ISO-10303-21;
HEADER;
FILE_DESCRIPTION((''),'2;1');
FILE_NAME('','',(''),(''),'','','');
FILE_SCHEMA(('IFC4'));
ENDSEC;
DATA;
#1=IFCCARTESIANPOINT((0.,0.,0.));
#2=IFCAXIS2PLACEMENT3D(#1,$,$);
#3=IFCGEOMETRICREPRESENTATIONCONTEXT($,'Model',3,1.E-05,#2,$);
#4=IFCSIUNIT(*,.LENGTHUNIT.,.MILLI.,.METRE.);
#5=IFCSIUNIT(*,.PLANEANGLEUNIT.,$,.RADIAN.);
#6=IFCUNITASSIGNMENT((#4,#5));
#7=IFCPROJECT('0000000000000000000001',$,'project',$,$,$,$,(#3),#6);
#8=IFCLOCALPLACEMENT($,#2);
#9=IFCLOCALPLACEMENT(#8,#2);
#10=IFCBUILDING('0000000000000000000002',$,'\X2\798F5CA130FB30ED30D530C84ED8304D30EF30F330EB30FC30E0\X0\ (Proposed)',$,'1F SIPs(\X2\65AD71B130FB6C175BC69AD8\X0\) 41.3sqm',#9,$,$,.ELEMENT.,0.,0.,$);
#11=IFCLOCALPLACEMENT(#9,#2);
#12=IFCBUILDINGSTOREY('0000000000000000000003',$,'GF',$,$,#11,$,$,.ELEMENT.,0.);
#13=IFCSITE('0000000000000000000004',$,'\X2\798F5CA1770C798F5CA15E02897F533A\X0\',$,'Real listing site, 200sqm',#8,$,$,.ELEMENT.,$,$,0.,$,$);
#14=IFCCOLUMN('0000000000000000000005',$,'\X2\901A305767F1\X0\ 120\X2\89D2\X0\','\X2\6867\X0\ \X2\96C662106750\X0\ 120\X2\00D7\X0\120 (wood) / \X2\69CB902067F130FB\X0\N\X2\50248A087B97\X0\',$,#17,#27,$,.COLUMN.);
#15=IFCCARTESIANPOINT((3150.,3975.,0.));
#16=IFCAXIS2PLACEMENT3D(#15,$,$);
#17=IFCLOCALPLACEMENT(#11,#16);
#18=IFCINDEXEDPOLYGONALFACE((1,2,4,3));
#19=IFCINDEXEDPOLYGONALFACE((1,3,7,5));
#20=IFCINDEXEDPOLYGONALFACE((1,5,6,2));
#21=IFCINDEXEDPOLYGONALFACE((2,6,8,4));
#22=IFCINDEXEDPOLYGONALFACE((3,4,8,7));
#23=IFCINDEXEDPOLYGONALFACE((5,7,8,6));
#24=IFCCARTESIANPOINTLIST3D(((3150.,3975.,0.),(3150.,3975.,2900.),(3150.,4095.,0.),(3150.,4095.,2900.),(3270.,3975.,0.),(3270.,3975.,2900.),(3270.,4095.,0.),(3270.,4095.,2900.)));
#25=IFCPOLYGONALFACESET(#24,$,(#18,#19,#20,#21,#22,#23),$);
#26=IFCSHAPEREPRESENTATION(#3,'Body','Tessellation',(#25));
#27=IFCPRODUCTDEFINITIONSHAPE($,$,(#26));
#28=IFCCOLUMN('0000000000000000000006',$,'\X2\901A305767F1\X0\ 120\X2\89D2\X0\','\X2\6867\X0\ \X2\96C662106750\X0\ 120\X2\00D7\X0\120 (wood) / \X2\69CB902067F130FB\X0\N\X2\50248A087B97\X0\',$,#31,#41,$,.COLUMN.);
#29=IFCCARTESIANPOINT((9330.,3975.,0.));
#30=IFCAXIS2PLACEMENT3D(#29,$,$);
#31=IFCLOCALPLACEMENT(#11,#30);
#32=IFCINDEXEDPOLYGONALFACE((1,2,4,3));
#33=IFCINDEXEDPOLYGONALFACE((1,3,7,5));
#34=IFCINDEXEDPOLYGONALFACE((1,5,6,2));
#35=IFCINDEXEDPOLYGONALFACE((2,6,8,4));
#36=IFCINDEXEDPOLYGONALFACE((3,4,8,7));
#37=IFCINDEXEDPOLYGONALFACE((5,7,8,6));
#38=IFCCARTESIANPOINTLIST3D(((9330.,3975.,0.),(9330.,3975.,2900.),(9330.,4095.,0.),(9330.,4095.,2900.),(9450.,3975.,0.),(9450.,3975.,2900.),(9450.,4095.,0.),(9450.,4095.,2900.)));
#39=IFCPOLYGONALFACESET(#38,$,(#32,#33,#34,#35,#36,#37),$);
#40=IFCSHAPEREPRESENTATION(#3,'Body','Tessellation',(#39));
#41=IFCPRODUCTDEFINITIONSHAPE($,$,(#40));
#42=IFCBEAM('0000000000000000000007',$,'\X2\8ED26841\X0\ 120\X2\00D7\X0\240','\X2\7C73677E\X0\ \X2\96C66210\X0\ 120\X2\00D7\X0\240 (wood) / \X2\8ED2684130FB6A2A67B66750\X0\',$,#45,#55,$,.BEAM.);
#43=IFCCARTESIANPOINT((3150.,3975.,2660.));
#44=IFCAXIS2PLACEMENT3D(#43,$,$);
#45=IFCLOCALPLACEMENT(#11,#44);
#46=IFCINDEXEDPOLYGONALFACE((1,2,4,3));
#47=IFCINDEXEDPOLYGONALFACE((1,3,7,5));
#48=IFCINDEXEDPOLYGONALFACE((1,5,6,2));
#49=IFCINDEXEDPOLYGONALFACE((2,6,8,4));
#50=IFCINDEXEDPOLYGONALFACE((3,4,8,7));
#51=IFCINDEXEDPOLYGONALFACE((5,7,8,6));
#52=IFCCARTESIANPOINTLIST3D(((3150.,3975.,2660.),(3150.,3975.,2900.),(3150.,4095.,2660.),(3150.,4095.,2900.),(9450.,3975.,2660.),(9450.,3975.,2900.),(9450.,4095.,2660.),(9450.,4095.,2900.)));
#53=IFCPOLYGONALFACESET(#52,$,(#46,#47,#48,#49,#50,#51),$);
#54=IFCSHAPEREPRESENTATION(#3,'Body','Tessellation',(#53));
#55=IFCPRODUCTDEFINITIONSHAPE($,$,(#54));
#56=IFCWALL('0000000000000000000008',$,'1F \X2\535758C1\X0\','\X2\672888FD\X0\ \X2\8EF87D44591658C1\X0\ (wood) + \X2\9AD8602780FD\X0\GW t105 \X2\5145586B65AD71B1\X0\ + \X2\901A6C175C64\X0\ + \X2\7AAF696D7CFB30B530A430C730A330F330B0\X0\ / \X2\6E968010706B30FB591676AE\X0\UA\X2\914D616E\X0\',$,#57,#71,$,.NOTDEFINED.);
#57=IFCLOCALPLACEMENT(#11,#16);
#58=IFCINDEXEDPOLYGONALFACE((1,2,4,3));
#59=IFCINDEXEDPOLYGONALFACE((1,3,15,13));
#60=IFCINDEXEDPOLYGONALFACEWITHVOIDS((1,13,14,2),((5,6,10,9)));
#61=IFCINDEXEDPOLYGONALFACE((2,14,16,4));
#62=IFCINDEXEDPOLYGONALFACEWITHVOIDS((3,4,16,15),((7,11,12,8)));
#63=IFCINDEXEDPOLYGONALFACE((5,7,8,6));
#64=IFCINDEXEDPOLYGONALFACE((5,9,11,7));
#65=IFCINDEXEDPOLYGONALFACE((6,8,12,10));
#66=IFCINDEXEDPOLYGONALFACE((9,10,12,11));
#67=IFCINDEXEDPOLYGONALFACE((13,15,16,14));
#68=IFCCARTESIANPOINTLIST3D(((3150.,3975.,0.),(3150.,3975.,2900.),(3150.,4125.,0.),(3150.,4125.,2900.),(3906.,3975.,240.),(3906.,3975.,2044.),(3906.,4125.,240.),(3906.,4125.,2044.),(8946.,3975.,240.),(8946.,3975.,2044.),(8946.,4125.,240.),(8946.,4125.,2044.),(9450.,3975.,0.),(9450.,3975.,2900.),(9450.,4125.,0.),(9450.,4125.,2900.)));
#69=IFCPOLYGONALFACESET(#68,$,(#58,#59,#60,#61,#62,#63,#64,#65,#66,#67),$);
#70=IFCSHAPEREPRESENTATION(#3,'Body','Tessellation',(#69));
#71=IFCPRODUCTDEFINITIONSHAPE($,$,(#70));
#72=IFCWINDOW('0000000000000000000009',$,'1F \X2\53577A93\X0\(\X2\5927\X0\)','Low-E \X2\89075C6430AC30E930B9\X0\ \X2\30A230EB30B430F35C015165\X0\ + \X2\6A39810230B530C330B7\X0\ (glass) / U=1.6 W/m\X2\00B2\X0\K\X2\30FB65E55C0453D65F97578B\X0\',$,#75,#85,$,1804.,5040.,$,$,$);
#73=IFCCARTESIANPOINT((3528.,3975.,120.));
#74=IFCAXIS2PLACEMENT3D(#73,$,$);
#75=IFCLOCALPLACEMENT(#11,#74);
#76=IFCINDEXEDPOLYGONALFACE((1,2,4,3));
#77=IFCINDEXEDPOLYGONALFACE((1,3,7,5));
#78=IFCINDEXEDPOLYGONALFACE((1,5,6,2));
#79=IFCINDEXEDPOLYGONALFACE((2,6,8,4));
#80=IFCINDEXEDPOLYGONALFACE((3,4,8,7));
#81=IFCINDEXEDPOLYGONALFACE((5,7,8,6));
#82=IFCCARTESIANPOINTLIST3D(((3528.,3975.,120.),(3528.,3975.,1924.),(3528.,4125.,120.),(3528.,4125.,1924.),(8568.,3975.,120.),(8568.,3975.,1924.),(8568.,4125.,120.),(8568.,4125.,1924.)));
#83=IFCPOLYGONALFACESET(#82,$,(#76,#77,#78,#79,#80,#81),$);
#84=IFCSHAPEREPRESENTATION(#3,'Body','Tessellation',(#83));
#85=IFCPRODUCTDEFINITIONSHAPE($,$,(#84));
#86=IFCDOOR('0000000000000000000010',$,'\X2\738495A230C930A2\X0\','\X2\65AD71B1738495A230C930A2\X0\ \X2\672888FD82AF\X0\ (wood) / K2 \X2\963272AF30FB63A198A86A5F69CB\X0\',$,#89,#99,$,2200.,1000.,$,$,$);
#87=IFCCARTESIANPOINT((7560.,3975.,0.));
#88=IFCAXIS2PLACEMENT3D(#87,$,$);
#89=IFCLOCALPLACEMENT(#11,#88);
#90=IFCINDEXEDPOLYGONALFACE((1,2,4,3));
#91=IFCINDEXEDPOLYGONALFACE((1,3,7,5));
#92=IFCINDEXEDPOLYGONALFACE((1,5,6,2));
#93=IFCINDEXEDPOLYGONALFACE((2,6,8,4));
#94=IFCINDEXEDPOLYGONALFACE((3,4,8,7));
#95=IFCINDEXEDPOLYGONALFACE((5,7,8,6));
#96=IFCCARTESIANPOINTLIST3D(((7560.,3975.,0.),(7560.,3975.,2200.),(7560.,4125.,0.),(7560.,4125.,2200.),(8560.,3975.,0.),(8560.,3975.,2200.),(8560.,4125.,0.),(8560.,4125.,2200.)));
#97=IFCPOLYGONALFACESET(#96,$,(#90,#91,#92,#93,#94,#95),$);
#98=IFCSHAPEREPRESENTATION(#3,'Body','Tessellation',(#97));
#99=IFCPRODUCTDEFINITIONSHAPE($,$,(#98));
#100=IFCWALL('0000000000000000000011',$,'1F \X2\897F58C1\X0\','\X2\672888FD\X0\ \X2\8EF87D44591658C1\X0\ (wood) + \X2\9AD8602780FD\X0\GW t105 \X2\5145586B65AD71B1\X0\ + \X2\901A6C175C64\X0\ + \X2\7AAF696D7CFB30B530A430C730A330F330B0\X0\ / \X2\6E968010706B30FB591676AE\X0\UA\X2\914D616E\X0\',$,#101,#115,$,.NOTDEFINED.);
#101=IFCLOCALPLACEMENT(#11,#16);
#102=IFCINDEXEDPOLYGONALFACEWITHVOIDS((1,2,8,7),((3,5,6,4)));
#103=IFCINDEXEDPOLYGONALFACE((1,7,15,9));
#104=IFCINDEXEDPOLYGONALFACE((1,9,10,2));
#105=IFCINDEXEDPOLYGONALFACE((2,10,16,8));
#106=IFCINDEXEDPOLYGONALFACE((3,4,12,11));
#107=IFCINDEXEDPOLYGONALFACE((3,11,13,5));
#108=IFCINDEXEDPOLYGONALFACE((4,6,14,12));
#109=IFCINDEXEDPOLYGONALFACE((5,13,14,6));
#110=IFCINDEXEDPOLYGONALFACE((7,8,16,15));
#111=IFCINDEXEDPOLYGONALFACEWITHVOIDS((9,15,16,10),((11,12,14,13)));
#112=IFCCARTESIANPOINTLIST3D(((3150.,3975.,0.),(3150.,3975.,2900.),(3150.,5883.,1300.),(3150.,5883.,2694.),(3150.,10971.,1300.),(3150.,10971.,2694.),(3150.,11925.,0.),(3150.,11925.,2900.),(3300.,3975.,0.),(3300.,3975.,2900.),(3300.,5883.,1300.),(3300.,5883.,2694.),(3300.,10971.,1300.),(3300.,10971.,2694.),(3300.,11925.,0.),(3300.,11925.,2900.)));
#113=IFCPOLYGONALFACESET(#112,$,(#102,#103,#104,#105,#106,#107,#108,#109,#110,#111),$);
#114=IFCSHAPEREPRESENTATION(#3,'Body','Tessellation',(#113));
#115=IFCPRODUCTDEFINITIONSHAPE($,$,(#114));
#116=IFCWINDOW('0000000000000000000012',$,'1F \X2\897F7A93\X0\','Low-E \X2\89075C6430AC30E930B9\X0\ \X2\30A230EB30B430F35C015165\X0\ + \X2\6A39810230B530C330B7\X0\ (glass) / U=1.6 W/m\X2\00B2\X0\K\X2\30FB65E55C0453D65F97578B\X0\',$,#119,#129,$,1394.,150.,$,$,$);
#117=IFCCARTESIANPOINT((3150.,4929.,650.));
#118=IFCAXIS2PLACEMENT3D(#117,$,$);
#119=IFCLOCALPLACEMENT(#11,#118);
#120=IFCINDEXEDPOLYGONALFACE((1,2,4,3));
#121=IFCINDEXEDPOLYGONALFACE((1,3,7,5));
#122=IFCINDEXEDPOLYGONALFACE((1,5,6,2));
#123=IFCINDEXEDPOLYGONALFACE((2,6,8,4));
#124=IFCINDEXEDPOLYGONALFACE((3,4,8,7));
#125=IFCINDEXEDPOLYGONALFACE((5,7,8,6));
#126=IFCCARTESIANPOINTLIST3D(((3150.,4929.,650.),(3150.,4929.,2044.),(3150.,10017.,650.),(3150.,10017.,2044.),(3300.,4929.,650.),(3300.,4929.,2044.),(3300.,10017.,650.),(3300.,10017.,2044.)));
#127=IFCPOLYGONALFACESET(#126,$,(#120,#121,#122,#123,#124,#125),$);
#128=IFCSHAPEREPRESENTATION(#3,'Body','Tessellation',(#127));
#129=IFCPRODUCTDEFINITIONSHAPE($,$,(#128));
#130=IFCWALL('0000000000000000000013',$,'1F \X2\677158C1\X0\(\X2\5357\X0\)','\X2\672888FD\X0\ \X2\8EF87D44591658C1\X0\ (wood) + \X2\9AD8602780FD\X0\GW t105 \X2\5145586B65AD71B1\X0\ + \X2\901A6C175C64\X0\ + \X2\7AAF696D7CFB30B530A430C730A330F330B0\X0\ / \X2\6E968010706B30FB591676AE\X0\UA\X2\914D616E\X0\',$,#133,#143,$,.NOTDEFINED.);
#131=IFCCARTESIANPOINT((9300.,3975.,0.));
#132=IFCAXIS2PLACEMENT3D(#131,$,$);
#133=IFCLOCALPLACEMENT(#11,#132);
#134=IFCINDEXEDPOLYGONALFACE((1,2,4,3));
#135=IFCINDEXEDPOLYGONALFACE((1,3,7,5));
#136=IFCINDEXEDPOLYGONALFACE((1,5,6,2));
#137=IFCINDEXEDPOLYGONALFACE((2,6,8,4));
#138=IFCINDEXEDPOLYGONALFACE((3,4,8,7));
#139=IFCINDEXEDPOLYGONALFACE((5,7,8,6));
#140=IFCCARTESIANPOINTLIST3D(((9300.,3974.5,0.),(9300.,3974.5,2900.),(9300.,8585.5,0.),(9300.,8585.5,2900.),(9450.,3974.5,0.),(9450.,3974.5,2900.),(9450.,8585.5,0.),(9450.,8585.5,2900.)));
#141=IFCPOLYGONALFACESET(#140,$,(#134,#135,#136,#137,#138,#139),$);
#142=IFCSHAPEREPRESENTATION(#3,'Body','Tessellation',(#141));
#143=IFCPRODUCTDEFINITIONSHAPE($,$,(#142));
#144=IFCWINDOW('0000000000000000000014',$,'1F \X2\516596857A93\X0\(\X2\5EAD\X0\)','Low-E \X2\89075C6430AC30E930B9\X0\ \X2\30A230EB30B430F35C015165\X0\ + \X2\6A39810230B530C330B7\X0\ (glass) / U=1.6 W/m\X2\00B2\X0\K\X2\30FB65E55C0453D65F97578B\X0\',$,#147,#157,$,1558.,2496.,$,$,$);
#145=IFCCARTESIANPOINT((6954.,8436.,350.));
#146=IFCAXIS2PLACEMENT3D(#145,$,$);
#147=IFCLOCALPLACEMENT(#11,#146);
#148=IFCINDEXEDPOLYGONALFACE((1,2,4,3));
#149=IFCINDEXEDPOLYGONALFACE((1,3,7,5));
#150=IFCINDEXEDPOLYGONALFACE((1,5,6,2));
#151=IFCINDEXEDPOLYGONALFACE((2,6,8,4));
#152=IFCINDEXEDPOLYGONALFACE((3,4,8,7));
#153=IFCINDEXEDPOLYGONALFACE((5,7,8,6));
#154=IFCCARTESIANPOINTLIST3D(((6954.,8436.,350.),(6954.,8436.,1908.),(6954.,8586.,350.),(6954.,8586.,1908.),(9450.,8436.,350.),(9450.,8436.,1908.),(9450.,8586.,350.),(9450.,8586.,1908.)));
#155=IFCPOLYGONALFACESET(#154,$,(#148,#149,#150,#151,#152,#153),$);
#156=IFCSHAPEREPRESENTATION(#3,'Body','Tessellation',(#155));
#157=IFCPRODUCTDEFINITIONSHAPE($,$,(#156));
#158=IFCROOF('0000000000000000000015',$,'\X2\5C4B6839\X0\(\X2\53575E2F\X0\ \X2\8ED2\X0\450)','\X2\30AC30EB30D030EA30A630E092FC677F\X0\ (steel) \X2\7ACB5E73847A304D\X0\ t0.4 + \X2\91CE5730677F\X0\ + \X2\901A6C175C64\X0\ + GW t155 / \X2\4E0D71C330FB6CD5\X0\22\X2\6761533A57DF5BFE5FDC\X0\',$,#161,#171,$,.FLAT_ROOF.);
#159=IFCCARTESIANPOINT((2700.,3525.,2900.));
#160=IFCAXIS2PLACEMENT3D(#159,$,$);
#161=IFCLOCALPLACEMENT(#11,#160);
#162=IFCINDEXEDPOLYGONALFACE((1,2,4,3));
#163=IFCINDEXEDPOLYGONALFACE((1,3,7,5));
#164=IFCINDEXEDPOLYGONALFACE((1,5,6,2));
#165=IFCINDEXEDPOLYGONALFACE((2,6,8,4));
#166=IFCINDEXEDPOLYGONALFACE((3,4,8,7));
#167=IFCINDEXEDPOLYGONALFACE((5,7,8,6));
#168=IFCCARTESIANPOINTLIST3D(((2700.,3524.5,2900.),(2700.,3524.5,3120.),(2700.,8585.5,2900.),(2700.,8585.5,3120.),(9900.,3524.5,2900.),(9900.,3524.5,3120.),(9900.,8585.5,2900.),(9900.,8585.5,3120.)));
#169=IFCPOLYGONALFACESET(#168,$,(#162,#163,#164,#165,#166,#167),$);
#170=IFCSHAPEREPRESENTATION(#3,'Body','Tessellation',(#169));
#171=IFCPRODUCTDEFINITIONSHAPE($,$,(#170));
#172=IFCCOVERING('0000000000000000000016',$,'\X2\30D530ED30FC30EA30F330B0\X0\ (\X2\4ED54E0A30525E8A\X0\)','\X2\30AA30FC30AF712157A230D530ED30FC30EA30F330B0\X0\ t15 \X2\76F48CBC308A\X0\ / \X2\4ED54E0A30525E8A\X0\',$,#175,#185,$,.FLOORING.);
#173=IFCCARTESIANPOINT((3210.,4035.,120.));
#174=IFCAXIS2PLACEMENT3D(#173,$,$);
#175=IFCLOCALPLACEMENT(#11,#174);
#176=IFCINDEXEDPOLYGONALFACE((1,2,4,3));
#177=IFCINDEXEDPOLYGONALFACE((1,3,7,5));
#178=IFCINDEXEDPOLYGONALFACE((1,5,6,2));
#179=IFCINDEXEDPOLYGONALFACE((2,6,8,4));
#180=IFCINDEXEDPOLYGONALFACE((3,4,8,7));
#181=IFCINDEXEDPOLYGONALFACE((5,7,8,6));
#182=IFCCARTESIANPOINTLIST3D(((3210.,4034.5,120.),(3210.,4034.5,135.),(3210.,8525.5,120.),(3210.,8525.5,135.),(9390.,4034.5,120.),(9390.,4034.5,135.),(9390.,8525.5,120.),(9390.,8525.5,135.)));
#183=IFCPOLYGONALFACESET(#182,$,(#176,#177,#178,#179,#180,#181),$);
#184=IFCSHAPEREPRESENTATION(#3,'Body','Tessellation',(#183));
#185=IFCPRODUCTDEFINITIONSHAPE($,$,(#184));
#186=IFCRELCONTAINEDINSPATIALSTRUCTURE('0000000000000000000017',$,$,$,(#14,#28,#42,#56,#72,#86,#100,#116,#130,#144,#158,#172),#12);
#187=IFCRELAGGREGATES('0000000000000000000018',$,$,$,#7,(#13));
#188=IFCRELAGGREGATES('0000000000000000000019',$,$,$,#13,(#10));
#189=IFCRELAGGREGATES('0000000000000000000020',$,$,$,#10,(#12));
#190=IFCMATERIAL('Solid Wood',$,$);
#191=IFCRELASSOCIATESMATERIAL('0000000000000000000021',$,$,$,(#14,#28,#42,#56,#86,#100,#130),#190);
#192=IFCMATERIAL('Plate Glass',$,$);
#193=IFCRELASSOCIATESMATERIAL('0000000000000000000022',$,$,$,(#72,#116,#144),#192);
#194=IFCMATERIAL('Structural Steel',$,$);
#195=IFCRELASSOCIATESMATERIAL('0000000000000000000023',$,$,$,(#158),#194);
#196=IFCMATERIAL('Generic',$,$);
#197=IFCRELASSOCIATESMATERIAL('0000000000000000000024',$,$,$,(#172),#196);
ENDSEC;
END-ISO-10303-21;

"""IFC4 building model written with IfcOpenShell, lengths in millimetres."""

from ifc_helpers import new_model, si_unit, frame, frame_2d, origin, place, context, project, spatial, rectangle, extrude, material, element, fill, save


model = new_model("IFC4")

# Units and contexts
model_context = context("Model", 3, precision=1e-05, world=origin())
ifc_project = project(units=[si_unit("LENGTHUNIT", "METRE", prefix="MILLI"), si_unit("PLANEANGLEUNIT", "RADIAN")], contexts=[model_context])

# Site, building, storey
site_placement = place(None, origin())
site = spatial("IfcSite", under=ifc_project, at=site_placement, Name="福岡県福岡市西区", ObjectType="Real listing site, 200sqm", CompositionType="ELEMENT", RefElevation=0.0)
building_placement = place(site_placement, origin())
building = spatial("IfcBuilding", under=site, at=building_placement, Name="福岡・ロフト付きワンルーム (Proposed)", ObjectType="1F SIPs(断熱・気密高) 41.3sqm", CompositionType="ELEMENT", ElevationOfRefHeight=0.0, ElevationOfTerrain=0.0)
storey_placement = place(building_placement, origin())
storey = spatial("IfcBuildingStorey", under=building, at=storey_placement, Name="GF", CompositionType="ELEMENT", Elevation=0.0)

# Columns
ifc_material_1 = material(Name="Solid Wood")
column_1_placement = place(storey_placement, frame((3150.0, 3975.0, 0.0)))
element("IfcColumn", 1, at=column_1_placement, inside=storey, material=ifc_material_1, Name="通し柱 120角", Description="桧 集成材 120×120 (wood) / 構造柱・N値計算", PredefinedType="COLUMN", context=model_context, shape_type="SweptSolid", body=[
    extrude(rectangle(XDim=120.0, YDim=120.0, at=frame_2d((60.0, 60.0))), frame((3150.0, 3975.0, 0.0)), (0.0, 0.0, 1.0), 2900.0),
])
column_2_placement = place(storey_placement, frame((9330.0, 3975.0, 0.0)))
element("IfcColumn", 2, at=column_2_placement, inside=storey, material=ifc_material_1, Name="通し柱 120角", Description="桧 集成材 120×120 (wood) / 構造柱・N値計算", PredefinedType="COLUMN", context=model_context, shape_type="SweptSolid", body=[
    extrude(rectangle(XDim=120.0, YDim=120.0, at=frame_2d((60.0, 60.0))), frame((9330.0, 3975.0, 0.0)), (0.0, 0.0, 1.0), 2900.0),
])

# Beam
beam_1_placement = place(storey_placement, frame((3150.0, 3975.0, 2660.0)))
element("IfcBeam", 3, at=beam_1_placement, inside=storey, material=ifc_material_1, Name="軒桁 120×240", Description="米松 集成 120×240 (wood) / 軒桁・横架材", PredefinedType="BEAM", context=model_context, shape_type="SweptSolid", body=[
    extrude(rectangle(XDim=6300.0, YDim=120.0, at=frame_2d((3150.0, 60.0))), frame((3150.0, 3975.0, 2660.0)), (0.0, 0.0, 1.0), 240.0),
])

# Wall, openings, window, door
wall_1_placement = place(storey_placement, frame((3150.0, 3975.0, 0.0)))
wall_1 = element("IfcWall", 4, at=wall_1_placement, inside=storey, material=ifc_material_1, Name="1F 南壁", Description="木製 軸組外壁 (wood) + 高性能GW t105 充填断熱 + 通気層 + 窯業系サイディング / 準耐火・外皮UA配慮", PredefinedType="NOTDEFINED", context=model_context, shape_type="SweptSolid", body=[
    extrude(rectangle(XDim=6300.0, YDim=150.0, at=frame_2d((3150.0, 75.0))), frame((3150.0, 3975.0, 0.0)), (0.0, 0.0, 1.0), 2900.0),
])
opening_1_placement = place(storey_placement, frame((3528.0, 3975.0, 120.0)))
opening_1 = element("IfcOpeningElement", 5, at=opening_1_placement, cuts=wall_1, PredefinedType="NOTDEFINED", context=model_context, shape_type="SweptSolid", body=[
    extrude(rectangle(XDim=5040.0, YDim=150.0, at=frame_2d((2520.0, 75.0))), frame((3528.0, 3975.0, 120.0)), (0.0, 0.0, 1.0), 1804.0),
])
opening_2_placement = place(storey_placement, frame((7560.0, 3975.0, 0.0)))
opening_2 = element("IfcOpeningElement", 6, at=opening_2_placement, cuts=wall_1, PredefinedType="NOTDEFINED", context=model_context, shape_type="SweptSolid", body=[
    extrude(rectangle(XDim=1000.0, YDim=150.0, at=frame_2d((500.0, 75.0))), frame((7560.0, 3975.0, 0.0)), (0.0, 0.0, 1.0), 2200.0),
])
ifc_material_2 = material(Name="Plate Glass")
window_1_placement = place(storey_placement, frame((3528.0, 3975.0, 120.0)))
window_1 = element("IfcWindow", 7, at=window_1_placement, inside=storey, material=ifc_material_2, Name="1F 南窓(大)", Description="Low-E 複層ガラス アルゴン封入 + 樹脂サッシ (glass) / U=1.6 W/m²K・日射取得型", OverallHeight=1804.0, OverallWidth=5040.0, context=model_context, shape_type="SweptSolid", body=[
    extrude(rectangle(XDim=5040.0, YDim=150.0, at=frame_2d((2520.0, 75.0))), frame((3528.0, 3975.0, 120.0)), (0.0, 0.0, 1.0), 1804.0),
])
fill(opening_1, window_1)
door_1_placement = place(storey_placement, frame((7560.0, 3975.0, 0.0)))
door_1 = element("IfcDoor", 8, at=door_1_placement, inside=storey, material=ifc_material_1, Name="玄関ドア", Description="断熱玄関ドア 木製芯 (wood) / K2 防犯・採風機構", OverallHeight=2200.0, OverallWidth=1000.0, context=model_context, shape_type="SweptSolid", body=[
    extrude(rectangle(XDim=1000.0, YDim=150.0, at=frame_2d((500.0, 75.0))), frame((7560.0, 3975.0, 0.0)), (0.0, 0.0, 1.0), 2200.0),
])
fill(opening_2, door_1)

# Walls, openings, windows
wall_2_placement = place(storey_placement, frame((3150.0, 3975.0, 0.0)))
wall_2 = element("IfcWall", 9, at=wall_2_placement, inside=storey, material=ifc_material_1, Name="1F 西壁", Description="木製 軸組外壁 (wood) + 高性能GW t105 充填断熱 + 通気層 + 窯業系サイディング / 準耐火・外皮UA配慮", PredefinedType="NOTDEFINED", context=model_context, shape_type="SweptSolid", body=[
    extrude(rectangle(XDim=150.0, YDim=7950.0, at=frame_2d((75.0, 3975.0))), frame((3150.0, 3975.0, 0.0)), (0.0, 0.0, 1.0), 2900.0),
])
opening_3_placement = place(storey_placement, frame((3150.0, 4929.0, 650.0)))
opening_3 = element("IfcOpeningElement", 10, at=opening_3_placement, cuts=wall_2, PredefinedType="NOTDEFINED", context=model_context, shape_type="SweptSolid", body=[
    extrude(rectangle(XDim=150.0, YDim=5088.0, at=frame_2d((75.0, 2544.0))), frame((3150.0, 4929.0, 650.0)), (0.0, 0.0, 1.0), 1394.0),
])
window_2_placement = place(storey_placement, frame((3150.0, 4929.0, 650.0)))
window_2 = element("IfcWindow", 11, at=window_2_placement, inside=storey, material=ifc_material_2, Name="1F 西窓", Description="Low-E 複層ガラス アルゴン封入 + 樹脂サッシ (glass) / U=1.6 W/m²K・日射取得型", OverallHeight=1394.0, OverallWidth=150.0, context=model_context, shape_type="SweptSolid", body=[
    extrude(rectangle(XDim=150.0, YDim=5088.0, at=frame_2d((75.0, 2544.0))), frame((3150.0, 4929.0, 650.0)), (0.0, 0.0, 1.0), 1394.0),
])
fill(opening_3, window_2)
wall_3_placement = place(storey_placement, frame((9300.0, 3975.0, 0.0)))
wall_3 = element("IfcWall", 12, at=wall_3_placement, inside=storey, material=ifc_material_1, Name="1F 東壁(南)", Description="木製 軸組外壁 (wood) + 高性能GW t105 充填断熱 + 通気層 + 窯業系サイディング / 準耐火・外皮UA配慮", PredefinedType="NOTDEFINED", context=model_context, shape_type="SweptSolid", body=[
    extrude(rectangle(XDim=150.0, YDim=4611.0, at=frame_2d((75.0, 2305.0))), frame((9300.0, 3975.0, 0.0)), (0.0, 0.0, 1.0), 2900.0),
])
opening_4_placement = place(storey_placement, frame((6954.0, 8436.0, 350.0)))
opening_4 = element("IfcOpeningElement", 13, at=opening_4_placement, cuts=wall_3, PredefinedType="NOTDEFINED", context=model_context, shape_type="SweptSolid", body=[
    extrude(rectangle(XDim=2496.0, YDim=150.0, at=frame_2d((1248.0, 75.0))), frame((6954.0, 8436.0, 350.0)), (0.0, 0.0, 1.0), 1558.0),
])
window_3_placement = place(storey_placement, frame((6954.0, 8436.0, 350.0)))
window_3 = element("IfcWindow", 14, at=window_3_placement, inside=storey, material=ifc_material_2, Name="1F 入隅窓(庭)", Description="Low-E 複層ガラス アルゴン封入 + 樹脂サッシ (glass) / U=1.6 W/m²K・日射取得型", OverallHeight=1558.0, OverallWidth=2496.0, context=model_context, shape_type="SweptSolid", body=[
    extrude(rectangle(XDim=2496.0, YDim=150.0, at=frame_2d((1248.0, 75.0))), frame((6954.0, 8436.0, 350.0)), (0.0, 0.0, 1.0), 1558.0),
])
fill(opening_4, window_3)

# Roof
ifc_material_3 = material(Name="Structural Steel")
roof_placement = place(storey_placement, frame((2700.0, 3525.0, 2900.0)))
element("IfcRoof", 15, at=roof_placement, inside=storey, material=ifc_material_3, Name="屋根(南帯 軒450)", Description="ガルバリウム鋼板 (steel) 立平葺き t0.4 + 野地板 + 通気層 + GW t155 / 不燃・法22条区域対応", PredefinedType="FLAT_ROOF", context=model_context, shape_type="SweptSolid", body=[
    extrude(rectangle(XDim=7200.0, YDim=5061.0, at=frame_2d((3600.0, 2530.0))), frame((2700.0, 3525.0, 2900.0)), (0.0, 0.0, 1.0), 220.0),
])

# Covering
ifc_material_4 = material(Name="Generic")
covering_1_placement = place(storey_placement, frame((3210.0, 4035.0, 120.0)))
element("IfcCovering", 16, at=covering_1_placement, inside=storey, material=ifc_material_4, Name="フローリング (仕上げ床)", Description="オーク無垢フローリング t15 直貼り / 仕上げ床", PredefinedType="FLOORING", context=model_context, shape_type="SweptSolid", body=[
    extrude(rectangle(XDim=6180.0, YDim=4491.0, at=frame_2d((3090.0, 2245.0))), frame((3210.0, 4035.0, 120.0)), (0.0, 0.0, 1.0), 15.0),
])

save(model, "model.ifc")
